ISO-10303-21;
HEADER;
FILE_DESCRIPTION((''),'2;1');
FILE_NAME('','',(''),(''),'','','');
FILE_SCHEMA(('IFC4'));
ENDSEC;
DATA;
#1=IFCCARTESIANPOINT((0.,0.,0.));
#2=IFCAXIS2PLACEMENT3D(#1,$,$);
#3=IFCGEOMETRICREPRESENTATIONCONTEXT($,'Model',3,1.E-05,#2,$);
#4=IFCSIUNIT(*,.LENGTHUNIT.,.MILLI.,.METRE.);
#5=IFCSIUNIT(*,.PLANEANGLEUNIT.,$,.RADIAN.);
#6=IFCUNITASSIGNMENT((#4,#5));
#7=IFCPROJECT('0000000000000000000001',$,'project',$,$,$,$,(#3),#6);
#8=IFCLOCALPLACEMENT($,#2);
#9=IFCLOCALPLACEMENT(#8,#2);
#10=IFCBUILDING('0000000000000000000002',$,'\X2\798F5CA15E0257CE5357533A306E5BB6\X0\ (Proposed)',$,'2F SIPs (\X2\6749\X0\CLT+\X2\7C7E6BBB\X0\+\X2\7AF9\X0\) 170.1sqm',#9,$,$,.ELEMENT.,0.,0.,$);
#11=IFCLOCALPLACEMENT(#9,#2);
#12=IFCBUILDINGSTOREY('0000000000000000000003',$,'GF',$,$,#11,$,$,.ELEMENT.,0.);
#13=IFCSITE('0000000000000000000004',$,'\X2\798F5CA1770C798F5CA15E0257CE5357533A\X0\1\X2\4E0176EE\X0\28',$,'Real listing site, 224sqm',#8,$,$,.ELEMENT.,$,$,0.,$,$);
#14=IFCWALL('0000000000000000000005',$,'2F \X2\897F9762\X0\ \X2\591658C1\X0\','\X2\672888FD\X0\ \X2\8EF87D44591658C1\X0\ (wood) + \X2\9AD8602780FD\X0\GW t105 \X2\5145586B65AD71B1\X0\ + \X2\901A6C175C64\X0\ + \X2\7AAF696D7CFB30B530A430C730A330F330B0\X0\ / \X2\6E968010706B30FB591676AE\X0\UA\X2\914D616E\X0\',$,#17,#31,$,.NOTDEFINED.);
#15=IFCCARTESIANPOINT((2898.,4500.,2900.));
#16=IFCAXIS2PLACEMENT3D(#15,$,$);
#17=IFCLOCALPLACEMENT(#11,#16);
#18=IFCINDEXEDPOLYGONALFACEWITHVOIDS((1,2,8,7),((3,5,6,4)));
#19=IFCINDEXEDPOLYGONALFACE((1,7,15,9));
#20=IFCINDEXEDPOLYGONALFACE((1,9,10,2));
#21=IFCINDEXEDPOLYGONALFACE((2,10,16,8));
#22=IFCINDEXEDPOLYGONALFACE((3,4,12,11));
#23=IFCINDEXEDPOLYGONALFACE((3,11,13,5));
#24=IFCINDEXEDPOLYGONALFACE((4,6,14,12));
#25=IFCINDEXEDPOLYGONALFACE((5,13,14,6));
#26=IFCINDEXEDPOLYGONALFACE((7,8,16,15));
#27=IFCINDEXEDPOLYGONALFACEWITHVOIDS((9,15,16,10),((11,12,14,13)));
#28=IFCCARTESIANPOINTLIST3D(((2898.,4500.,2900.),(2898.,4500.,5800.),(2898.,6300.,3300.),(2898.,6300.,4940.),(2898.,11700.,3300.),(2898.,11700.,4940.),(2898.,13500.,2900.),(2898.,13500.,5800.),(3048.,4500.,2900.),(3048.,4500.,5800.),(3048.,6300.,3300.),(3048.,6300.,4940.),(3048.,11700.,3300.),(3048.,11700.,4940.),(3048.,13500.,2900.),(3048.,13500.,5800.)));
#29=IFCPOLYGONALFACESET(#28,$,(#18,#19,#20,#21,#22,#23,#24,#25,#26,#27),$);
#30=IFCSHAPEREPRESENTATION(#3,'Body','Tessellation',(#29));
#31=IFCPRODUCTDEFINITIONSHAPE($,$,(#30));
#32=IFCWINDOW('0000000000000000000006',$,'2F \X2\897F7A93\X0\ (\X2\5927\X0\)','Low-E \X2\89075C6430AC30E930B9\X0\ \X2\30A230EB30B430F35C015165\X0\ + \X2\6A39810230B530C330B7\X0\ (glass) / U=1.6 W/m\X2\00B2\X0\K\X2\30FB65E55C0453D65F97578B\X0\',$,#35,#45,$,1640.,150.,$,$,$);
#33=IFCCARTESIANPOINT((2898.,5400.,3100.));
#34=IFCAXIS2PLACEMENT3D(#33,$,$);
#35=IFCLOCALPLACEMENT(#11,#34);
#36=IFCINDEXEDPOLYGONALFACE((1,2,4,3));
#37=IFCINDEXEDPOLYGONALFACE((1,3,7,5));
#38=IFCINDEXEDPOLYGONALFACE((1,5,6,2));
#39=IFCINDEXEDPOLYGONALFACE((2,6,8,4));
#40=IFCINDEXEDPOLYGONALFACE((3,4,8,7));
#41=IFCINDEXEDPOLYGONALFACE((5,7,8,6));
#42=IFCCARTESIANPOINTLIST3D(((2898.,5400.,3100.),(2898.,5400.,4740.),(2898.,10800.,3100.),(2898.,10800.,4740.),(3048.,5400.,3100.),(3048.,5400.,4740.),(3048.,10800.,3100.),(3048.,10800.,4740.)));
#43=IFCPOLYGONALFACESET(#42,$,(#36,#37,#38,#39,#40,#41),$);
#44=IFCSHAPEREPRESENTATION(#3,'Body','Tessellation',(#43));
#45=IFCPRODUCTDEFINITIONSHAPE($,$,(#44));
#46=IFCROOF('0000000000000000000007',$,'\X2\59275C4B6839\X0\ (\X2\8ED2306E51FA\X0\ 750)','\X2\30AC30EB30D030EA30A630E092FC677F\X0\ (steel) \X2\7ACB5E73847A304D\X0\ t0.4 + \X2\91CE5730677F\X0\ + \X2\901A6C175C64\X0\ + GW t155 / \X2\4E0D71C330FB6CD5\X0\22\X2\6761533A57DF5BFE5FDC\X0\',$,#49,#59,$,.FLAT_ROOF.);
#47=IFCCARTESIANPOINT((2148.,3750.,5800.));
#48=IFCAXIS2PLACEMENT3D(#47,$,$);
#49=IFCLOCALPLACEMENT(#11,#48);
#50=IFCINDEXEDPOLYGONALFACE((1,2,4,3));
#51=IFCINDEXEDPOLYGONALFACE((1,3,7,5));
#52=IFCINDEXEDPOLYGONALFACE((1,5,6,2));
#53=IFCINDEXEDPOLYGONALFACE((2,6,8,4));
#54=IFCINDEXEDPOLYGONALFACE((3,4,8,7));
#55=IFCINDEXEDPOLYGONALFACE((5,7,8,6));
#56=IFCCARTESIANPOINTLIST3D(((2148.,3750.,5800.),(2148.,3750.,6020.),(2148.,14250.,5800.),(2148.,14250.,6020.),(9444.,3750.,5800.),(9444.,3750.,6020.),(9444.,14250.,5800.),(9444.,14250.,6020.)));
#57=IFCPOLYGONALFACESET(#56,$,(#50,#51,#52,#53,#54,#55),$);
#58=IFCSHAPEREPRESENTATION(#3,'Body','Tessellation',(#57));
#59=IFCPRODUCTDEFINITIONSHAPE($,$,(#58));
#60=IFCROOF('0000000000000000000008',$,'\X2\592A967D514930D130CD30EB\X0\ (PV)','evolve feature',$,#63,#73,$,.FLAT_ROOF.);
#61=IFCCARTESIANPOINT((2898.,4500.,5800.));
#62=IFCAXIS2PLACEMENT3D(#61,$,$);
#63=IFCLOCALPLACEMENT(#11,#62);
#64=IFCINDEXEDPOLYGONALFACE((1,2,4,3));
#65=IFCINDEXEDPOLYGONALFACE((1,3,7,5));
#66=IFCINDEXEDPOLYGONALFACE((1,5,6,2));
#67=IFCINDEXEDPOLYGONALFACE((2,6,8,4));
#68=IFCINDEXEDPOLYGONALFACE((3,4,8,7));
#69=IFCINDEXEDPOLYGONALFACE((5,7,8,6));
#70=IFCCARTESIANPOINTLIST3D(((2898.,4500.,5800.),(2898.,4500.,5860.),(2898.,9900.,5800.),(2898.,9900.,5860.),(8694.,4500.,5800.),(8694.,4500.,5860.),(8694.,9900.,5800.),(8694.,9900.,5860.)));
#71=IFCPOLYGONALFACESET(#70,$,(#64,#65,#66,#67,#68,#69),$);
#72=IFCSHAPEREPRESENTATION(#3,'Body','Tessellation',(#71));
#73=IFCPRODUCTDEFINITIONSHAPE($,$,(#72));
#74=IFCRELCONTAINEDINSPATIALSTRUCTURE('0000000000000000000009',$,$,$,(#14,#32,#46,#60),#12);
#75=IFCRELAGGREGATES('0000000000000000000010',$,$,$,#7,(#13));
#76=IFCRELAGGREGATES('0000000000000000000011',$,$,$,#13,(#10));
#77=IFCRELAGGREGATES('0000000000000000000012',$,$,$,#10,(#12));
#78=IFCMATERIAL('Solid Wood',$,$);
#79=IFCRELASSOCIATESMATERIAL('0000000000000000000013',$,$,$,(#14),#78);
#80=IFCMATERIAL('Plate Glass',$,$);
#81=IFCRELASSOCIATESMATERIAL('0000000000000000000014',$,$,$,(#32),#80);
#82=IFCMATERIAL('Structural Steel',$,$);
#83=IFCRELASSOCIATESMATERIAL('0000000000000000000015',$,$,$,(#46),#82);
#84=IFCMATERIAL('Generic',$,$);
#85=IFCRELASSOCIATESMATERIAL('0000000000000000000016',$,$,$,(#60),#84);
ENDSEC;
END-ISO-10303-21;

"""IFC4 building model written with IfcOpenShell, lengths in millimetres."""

from ifc_helpers import new_model, si_unit, frame, frame_2d, origin, place, context, project, spatial, rectangle, extrude, material, element, fill, save


model = new_model("IFC4")

# Units and contexts
model_context = context("Model", 3, precision=1e-05, world=origin())
ifc_project = project(units=[si_unit("LENGTHUNIT", "METRE", prefix="MILLI"), si_unit("PLANEANGLEUNIT", "RADIAN")], contexts=[model_context])

# Site, building, storey
site_placement = place(None, origin())
site = spatial("IfcSite", under=ifc_project, at=site_placement, Name="福岡県福岡市城南区1丁目28", ObjectType="Real listing site, 224sqm", CompositionType="ELEMENT", RefElevation=0.0)
building_placement = place(site_placement, origin())
building = spatial("IfcBuilding", under=site, at=building_placement, Name="福岡市城南区の家 (Proposed)", ObjectType="2F SIPs (杉CLT+籾殻+竹) 170.1sqm", CompositionType="ELEMENT", ElevationOfRefHeight=0.0, ElevationOfTerrain=0.0)
storey_placement = place(building_placement, origin())
storey = spatial("IfcBuildingStorey", under=building, at=storey_placement, Name="GF", CompositionType="ELEMENT", Elevation=0.0)

# Shared definitions
ifc_material_1 = material(Name="Solid Wood")
ifc_material_2 = material(Name="Generic")

# Shared definitions
ifc_material_3 = material(Name="Plate Glass")

# Wall, opening, window
wall_1_placement = place(storey_placement, frame((2898.0, 4500.0, 2900.0)))
wall_1 = element("IfcWall", 1, at=wall_1_placement, inside=storey, material=ifc_material_1, Name="2F 西面 外壁", Description="木製 軸組外壁 (wood) + 高性能GW t105 充填断熱 + 通気層 + 窯業系サイディング / 準耐火・外皮UA配慮", PredefinedType="NOTDEFINED", context=model_context, shape_type="SweptSolid", body=[
    extrude(rectangle(XDim=150.0, YDim=9000.0, at=frame_2d((75.0, 4500.0))), frame((2898.0, 4500.0, 2900.0)), (0.0, 0.0, 1.0), 2900.0),
])
opening_1_placement = place(storey_placement, frame((2898.0, 5400.0, 3100.0)))
opening_1 = element("IfcOpeningElement", 2, at=opening_1_placement, cuts=wall_1, PredefinedType="NOTDEFINED", context=model_context, shape_type="SweptSolid", body=[
    extrude(rectangle(XDim=150.0, YDim=5400.0, at=frame_2d((75.0, 2700.0))), frame((2898.0, 5400.0, 3100.0)), (0.0, 0.0, 1.0), 1640.0),
])
window_1_placement = place(storey_placement, frame((2898.0, 5400.0, 3100.0)))
window_1 = element("IfcWindow", 3, at=window_1_placement, inside=storey, material=ifc_material_3, Name="2F 西窓 (大)", Description="Low-E 複層ガラス アルゴン封入 + 樹脂サッシ (glass) / U=1.6 W/m²K・日射取得型", OverallHeight=1640.0, OverallWidth=150.0, context=model_context, shape_type="SweptSolid", body=[
    extrude(rectangle(XDim=150.0, YDim=5400.0, at=frame_2d((75.0, 2700.0))), frame((2898.0, 5400.0, 3100.0)), (0.0, 0.0, 1.0), 1640.0),
])
fill(opening_1, window_1)

# Roofs
ifc_material_4 = material(Name="Structural Steel")
roof_1_placement = place(storey_placement, frame((2148.0, 3750.0, 5800.0)))
element("IfcRoof", 4, at=roof_1_placement, inside=storey, material=ifc_material_4, Name="大屋根 (軒の出 750)", Description="ガルバリウム鋼板 (steel) 立平葺き t0.4 + 野地板 + 通気層 + GW t155 / 不燃・法22条区域対応", PredefinedType="FLAT_ROOF", context=model_context, shape_type="SweptSolid", body=[
    extrude(rectangle(XDim=7296.0, YDim=10500.0, at=frame_2d((3648.0, 5250.0))), frame((2148.0, 3750.0, 5800.0)), (0.0, 0.0, 1.0), 220.0),
])
roof_2_placement = place(storey_placement, frame((2898.0, 4500.0, 5800.0)))
element("IfcRoof", 5, at=roof_2_placement, inside=storey, material=ifc_material_2, Name="太陽光パネル (PV)", Description="evolve feature", PredefinedType="FLAT_ROOF", context=model_context, shape_type="SweptSolid", body=[
    extrude(rectangle(XDim=5796.0, YDim=5400.0, at=frame_2d((2898.0, 2700.0))), frame((2898.0, 4500.0, 5800.0)), (0.0, 0.0, 1.0), 60.0),
])

save(model, "model.ifc")
